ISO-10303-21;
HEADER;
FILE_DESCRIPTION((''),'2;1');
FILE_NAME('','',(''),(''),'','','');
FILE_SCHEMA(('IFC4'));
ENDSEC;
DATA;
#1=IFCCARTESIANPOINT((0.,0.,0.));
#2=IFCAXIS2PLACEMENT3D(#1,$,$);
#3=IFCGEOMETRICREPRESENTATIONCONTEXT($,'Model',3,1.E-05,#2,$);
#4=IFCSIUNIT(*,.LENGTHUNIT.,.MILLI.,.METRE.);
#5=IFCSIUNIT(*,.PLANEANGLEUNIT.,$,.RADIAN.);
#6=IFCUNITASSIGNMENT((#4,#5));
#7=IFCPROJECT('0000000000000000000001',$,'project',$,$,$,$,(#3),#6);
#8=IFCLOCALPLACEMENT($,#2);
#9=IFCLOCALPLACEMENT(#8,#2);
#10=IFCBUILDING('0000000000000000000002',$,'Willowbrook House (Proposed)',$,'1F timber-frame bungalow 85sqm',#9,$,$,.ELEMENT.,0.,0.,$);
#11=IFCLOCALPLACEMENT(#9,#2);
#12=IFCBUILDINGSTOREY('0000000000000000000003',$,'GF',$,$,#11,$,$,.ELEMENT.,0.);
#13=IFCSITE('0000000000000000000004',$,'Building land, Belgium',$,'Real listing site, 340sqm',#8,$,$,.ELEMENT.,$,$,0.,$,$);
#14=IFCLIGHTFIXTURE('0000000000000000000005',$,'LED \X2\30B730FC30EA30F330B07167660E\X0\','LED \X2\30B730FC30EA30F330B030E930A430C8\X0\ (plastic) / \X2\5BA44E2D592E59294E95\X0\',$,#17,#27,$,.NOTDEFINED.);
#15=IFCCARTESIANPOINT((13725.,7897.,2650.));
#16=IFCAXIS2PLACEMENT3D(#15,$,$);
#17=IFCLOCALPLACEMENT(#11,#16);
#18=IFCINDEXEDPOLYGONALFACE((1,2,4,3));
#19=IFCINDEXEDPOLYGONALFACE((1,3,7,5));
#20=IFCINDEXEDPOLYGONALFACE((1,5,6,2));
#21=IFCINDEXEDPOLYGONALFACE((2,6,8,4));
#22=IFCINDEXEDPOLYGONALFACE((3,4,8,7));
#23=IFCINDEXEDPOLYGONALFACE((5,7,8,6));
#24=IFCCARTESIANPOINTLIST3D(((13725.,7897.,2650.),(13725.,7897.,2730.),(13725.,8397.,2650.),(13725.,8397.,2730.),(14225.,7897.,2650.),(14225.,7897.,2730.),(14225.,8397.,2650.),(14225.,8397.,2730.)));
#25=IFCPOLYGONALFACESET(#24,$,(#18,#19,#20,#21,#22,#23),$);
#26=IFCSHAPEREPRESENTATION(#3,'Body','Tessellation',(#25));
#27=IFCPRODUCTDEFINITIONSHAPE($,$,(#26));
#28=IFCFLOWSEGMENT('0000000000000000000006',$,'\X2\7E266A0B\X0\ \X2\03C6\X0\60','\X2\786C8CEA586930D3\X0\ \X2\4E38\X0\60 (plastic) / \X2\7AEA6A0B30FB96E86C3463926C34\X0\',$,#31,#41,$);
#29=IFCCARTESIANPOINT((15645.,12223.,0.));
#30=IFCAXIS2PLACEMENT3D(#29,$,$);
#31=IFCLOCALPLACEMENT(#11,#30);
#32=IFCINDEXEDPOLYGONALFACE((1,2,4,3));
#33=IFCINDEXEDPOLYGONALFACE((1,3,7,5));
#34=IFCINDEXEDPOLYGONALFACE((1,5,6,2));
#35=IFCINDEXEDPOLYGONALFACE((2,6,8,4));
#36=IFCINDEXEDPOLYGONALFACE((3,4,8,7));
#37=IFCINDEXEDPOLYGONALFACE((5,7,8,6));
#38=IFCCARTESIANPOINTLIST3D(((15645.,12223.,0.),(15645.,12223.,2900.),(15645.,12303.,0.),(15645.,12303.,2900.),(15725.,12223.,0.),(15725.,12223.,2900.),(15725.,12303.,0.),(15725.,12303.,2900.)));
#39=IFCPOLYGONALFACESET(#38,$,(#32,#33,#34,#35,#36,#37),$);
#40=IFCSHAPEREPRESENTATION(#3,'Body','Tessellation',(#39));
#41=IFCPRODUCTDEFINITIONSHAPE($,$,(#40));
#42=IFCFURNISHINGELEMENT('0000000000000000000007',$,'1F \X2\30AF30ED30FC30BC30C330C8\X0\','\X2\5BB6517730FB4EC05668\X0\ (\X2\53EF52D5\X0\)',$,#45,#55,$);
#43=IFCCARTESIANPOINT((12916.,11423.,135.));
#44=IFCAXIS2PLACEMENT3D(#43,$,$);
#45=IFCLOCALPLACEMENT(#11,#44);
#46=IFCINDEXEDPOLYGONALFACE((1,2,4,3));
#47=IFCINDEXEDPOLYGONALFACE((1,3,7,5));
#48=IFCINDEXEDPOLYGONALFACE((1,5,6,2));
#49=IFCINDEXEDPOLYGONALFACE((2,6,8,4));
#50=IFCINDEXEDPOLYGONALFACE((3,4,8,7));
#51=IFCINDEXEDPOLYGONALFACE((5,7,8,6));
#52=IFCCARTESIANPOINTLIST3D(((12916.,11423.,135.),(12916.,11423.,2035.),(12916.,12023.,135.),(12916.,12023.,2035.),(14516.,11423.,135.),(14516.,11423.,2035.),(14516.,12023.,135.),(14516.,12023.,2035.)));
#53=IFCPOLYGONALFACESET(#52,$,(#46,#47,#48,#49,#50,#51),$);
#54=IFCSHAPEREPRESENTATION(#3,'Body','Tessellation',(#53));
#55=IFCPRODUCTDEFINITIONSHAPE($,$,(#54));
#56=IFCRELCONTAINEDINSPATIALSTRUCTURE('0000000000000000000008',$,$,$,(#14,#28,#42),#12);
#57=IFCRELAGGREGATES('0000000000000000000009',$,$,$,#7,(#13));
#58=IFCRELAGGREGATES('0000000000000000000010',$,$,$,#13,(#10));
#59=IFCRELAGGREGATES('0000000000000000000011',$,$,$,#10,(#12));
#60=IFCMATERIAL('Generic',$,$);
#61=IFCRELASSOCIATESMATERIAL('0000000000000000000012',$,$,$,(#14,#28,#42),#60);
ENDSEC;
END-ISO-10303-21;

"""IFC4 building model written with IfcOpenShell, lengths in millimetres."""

from ifc_helpers import new_model, si_unit, frame, frame_2d, origin, place, context, project, spatial, rectangle, extrude, material, element, save


model = new_model("IFC4")

# Units and contexts
model_context = context("Model", 3, precision=1e-05, world=origin())
ifc_project = project(units=[si_unit("LENGTHUNIT", "METRE", prefix="MILLI"), si_unit("PLANEANGLEUNIT", "RADIAN")], contexts=[model_context])

# Site, building, storey
site_placement = place(None, origin())
site = spatial("IfcSite", under=ifc_project, at=site_placement, Name="Building land, Belgium", ObjectType="Real listing site, 340sqm", CompositionType="ELEMENT", RefElevation=0.0)
building_placement = place(site_placement, origin())
building = spatial("IfcBuilding", under=site, at=building_placement, Name="Willowbrook House (Proposed)", ObjectType="1F timber-frame bungalow 85sqm", CompositionType="ELEMENT", ElevationOfRefHeight=0.0, ElevationOfTerrain=0.0)
storey_placement = place(building_placement, origin())
storey = spatial("IfcBuildingStorey", under=building, at=storey_placement, Name="GF", CompositionType="ELEMENT", Elevation=0.0)

# Shared definitions
ifc_material_1 = material(Name="Generic")

# Light fixture
light_fixture_1_placement = place(storey_placement, frame((13725.0, 7897.0, 2650.0)))
element("IfcLightFixture", 1, at=light_fixture_1_placement, inside=storey, material=ifc_material_1, Name="LED シーリング照明", Description="LED シーリングライト (plastic) / 室中央天井", PredefinedType="NOTDEFINED", context=model_context, shape_type="SweptSolid", body=[
    extrude(rectangle(XDim=500.0, YDim=500.0, at=frame_2d((250.0, 250.0))), frame((13725.0, 7897.0, 2650.0)), (0.0, 0.0, 1.0), 80.0),
])

# Flow segment
flow_segment_placement = place(storey_placement, frame((15645.0, 12223.0, 0.0)))
element("IfcFlowSegment", 2, at=flow_segment_placement, inside=storey, material=ifc_material_1, Name="縦樋 φ60", Description="硬質塩ビ 丸60 (plastic) / 竪樋・雨水排水", context=model_context, shape_type="SweptSolid", body=[
    extrude(rectangle(XDim=80.0, YDim=80.0, at=frame_2d((40.0, 40.0))), frame((15645.0, 12223.0, 0.0)), (0.0, 0.0, 1.0), 2900.0),
])

# Furnishing element
furnishing_placement = place(storey_placement, frame((12916.0, 11423.0, 135.0)))
element("IfcFurnishingElement", 3, at=furnishing_placement, inside=storey, material=ifc_material_1, Name="1F クローゼット", Description="家具・什器 (可動)", context=model_context, shape_type="SweptSolid", body=[
    extrude(rectangle(XDim=1600.0, YDim=600.0, at=frame_2d((800.0, 300.0))), frame((12916.0, 11423.0, 135.0)), (0.0, 0.0, 1.0), 1900.0),
])

save(model, "model.ifc")
